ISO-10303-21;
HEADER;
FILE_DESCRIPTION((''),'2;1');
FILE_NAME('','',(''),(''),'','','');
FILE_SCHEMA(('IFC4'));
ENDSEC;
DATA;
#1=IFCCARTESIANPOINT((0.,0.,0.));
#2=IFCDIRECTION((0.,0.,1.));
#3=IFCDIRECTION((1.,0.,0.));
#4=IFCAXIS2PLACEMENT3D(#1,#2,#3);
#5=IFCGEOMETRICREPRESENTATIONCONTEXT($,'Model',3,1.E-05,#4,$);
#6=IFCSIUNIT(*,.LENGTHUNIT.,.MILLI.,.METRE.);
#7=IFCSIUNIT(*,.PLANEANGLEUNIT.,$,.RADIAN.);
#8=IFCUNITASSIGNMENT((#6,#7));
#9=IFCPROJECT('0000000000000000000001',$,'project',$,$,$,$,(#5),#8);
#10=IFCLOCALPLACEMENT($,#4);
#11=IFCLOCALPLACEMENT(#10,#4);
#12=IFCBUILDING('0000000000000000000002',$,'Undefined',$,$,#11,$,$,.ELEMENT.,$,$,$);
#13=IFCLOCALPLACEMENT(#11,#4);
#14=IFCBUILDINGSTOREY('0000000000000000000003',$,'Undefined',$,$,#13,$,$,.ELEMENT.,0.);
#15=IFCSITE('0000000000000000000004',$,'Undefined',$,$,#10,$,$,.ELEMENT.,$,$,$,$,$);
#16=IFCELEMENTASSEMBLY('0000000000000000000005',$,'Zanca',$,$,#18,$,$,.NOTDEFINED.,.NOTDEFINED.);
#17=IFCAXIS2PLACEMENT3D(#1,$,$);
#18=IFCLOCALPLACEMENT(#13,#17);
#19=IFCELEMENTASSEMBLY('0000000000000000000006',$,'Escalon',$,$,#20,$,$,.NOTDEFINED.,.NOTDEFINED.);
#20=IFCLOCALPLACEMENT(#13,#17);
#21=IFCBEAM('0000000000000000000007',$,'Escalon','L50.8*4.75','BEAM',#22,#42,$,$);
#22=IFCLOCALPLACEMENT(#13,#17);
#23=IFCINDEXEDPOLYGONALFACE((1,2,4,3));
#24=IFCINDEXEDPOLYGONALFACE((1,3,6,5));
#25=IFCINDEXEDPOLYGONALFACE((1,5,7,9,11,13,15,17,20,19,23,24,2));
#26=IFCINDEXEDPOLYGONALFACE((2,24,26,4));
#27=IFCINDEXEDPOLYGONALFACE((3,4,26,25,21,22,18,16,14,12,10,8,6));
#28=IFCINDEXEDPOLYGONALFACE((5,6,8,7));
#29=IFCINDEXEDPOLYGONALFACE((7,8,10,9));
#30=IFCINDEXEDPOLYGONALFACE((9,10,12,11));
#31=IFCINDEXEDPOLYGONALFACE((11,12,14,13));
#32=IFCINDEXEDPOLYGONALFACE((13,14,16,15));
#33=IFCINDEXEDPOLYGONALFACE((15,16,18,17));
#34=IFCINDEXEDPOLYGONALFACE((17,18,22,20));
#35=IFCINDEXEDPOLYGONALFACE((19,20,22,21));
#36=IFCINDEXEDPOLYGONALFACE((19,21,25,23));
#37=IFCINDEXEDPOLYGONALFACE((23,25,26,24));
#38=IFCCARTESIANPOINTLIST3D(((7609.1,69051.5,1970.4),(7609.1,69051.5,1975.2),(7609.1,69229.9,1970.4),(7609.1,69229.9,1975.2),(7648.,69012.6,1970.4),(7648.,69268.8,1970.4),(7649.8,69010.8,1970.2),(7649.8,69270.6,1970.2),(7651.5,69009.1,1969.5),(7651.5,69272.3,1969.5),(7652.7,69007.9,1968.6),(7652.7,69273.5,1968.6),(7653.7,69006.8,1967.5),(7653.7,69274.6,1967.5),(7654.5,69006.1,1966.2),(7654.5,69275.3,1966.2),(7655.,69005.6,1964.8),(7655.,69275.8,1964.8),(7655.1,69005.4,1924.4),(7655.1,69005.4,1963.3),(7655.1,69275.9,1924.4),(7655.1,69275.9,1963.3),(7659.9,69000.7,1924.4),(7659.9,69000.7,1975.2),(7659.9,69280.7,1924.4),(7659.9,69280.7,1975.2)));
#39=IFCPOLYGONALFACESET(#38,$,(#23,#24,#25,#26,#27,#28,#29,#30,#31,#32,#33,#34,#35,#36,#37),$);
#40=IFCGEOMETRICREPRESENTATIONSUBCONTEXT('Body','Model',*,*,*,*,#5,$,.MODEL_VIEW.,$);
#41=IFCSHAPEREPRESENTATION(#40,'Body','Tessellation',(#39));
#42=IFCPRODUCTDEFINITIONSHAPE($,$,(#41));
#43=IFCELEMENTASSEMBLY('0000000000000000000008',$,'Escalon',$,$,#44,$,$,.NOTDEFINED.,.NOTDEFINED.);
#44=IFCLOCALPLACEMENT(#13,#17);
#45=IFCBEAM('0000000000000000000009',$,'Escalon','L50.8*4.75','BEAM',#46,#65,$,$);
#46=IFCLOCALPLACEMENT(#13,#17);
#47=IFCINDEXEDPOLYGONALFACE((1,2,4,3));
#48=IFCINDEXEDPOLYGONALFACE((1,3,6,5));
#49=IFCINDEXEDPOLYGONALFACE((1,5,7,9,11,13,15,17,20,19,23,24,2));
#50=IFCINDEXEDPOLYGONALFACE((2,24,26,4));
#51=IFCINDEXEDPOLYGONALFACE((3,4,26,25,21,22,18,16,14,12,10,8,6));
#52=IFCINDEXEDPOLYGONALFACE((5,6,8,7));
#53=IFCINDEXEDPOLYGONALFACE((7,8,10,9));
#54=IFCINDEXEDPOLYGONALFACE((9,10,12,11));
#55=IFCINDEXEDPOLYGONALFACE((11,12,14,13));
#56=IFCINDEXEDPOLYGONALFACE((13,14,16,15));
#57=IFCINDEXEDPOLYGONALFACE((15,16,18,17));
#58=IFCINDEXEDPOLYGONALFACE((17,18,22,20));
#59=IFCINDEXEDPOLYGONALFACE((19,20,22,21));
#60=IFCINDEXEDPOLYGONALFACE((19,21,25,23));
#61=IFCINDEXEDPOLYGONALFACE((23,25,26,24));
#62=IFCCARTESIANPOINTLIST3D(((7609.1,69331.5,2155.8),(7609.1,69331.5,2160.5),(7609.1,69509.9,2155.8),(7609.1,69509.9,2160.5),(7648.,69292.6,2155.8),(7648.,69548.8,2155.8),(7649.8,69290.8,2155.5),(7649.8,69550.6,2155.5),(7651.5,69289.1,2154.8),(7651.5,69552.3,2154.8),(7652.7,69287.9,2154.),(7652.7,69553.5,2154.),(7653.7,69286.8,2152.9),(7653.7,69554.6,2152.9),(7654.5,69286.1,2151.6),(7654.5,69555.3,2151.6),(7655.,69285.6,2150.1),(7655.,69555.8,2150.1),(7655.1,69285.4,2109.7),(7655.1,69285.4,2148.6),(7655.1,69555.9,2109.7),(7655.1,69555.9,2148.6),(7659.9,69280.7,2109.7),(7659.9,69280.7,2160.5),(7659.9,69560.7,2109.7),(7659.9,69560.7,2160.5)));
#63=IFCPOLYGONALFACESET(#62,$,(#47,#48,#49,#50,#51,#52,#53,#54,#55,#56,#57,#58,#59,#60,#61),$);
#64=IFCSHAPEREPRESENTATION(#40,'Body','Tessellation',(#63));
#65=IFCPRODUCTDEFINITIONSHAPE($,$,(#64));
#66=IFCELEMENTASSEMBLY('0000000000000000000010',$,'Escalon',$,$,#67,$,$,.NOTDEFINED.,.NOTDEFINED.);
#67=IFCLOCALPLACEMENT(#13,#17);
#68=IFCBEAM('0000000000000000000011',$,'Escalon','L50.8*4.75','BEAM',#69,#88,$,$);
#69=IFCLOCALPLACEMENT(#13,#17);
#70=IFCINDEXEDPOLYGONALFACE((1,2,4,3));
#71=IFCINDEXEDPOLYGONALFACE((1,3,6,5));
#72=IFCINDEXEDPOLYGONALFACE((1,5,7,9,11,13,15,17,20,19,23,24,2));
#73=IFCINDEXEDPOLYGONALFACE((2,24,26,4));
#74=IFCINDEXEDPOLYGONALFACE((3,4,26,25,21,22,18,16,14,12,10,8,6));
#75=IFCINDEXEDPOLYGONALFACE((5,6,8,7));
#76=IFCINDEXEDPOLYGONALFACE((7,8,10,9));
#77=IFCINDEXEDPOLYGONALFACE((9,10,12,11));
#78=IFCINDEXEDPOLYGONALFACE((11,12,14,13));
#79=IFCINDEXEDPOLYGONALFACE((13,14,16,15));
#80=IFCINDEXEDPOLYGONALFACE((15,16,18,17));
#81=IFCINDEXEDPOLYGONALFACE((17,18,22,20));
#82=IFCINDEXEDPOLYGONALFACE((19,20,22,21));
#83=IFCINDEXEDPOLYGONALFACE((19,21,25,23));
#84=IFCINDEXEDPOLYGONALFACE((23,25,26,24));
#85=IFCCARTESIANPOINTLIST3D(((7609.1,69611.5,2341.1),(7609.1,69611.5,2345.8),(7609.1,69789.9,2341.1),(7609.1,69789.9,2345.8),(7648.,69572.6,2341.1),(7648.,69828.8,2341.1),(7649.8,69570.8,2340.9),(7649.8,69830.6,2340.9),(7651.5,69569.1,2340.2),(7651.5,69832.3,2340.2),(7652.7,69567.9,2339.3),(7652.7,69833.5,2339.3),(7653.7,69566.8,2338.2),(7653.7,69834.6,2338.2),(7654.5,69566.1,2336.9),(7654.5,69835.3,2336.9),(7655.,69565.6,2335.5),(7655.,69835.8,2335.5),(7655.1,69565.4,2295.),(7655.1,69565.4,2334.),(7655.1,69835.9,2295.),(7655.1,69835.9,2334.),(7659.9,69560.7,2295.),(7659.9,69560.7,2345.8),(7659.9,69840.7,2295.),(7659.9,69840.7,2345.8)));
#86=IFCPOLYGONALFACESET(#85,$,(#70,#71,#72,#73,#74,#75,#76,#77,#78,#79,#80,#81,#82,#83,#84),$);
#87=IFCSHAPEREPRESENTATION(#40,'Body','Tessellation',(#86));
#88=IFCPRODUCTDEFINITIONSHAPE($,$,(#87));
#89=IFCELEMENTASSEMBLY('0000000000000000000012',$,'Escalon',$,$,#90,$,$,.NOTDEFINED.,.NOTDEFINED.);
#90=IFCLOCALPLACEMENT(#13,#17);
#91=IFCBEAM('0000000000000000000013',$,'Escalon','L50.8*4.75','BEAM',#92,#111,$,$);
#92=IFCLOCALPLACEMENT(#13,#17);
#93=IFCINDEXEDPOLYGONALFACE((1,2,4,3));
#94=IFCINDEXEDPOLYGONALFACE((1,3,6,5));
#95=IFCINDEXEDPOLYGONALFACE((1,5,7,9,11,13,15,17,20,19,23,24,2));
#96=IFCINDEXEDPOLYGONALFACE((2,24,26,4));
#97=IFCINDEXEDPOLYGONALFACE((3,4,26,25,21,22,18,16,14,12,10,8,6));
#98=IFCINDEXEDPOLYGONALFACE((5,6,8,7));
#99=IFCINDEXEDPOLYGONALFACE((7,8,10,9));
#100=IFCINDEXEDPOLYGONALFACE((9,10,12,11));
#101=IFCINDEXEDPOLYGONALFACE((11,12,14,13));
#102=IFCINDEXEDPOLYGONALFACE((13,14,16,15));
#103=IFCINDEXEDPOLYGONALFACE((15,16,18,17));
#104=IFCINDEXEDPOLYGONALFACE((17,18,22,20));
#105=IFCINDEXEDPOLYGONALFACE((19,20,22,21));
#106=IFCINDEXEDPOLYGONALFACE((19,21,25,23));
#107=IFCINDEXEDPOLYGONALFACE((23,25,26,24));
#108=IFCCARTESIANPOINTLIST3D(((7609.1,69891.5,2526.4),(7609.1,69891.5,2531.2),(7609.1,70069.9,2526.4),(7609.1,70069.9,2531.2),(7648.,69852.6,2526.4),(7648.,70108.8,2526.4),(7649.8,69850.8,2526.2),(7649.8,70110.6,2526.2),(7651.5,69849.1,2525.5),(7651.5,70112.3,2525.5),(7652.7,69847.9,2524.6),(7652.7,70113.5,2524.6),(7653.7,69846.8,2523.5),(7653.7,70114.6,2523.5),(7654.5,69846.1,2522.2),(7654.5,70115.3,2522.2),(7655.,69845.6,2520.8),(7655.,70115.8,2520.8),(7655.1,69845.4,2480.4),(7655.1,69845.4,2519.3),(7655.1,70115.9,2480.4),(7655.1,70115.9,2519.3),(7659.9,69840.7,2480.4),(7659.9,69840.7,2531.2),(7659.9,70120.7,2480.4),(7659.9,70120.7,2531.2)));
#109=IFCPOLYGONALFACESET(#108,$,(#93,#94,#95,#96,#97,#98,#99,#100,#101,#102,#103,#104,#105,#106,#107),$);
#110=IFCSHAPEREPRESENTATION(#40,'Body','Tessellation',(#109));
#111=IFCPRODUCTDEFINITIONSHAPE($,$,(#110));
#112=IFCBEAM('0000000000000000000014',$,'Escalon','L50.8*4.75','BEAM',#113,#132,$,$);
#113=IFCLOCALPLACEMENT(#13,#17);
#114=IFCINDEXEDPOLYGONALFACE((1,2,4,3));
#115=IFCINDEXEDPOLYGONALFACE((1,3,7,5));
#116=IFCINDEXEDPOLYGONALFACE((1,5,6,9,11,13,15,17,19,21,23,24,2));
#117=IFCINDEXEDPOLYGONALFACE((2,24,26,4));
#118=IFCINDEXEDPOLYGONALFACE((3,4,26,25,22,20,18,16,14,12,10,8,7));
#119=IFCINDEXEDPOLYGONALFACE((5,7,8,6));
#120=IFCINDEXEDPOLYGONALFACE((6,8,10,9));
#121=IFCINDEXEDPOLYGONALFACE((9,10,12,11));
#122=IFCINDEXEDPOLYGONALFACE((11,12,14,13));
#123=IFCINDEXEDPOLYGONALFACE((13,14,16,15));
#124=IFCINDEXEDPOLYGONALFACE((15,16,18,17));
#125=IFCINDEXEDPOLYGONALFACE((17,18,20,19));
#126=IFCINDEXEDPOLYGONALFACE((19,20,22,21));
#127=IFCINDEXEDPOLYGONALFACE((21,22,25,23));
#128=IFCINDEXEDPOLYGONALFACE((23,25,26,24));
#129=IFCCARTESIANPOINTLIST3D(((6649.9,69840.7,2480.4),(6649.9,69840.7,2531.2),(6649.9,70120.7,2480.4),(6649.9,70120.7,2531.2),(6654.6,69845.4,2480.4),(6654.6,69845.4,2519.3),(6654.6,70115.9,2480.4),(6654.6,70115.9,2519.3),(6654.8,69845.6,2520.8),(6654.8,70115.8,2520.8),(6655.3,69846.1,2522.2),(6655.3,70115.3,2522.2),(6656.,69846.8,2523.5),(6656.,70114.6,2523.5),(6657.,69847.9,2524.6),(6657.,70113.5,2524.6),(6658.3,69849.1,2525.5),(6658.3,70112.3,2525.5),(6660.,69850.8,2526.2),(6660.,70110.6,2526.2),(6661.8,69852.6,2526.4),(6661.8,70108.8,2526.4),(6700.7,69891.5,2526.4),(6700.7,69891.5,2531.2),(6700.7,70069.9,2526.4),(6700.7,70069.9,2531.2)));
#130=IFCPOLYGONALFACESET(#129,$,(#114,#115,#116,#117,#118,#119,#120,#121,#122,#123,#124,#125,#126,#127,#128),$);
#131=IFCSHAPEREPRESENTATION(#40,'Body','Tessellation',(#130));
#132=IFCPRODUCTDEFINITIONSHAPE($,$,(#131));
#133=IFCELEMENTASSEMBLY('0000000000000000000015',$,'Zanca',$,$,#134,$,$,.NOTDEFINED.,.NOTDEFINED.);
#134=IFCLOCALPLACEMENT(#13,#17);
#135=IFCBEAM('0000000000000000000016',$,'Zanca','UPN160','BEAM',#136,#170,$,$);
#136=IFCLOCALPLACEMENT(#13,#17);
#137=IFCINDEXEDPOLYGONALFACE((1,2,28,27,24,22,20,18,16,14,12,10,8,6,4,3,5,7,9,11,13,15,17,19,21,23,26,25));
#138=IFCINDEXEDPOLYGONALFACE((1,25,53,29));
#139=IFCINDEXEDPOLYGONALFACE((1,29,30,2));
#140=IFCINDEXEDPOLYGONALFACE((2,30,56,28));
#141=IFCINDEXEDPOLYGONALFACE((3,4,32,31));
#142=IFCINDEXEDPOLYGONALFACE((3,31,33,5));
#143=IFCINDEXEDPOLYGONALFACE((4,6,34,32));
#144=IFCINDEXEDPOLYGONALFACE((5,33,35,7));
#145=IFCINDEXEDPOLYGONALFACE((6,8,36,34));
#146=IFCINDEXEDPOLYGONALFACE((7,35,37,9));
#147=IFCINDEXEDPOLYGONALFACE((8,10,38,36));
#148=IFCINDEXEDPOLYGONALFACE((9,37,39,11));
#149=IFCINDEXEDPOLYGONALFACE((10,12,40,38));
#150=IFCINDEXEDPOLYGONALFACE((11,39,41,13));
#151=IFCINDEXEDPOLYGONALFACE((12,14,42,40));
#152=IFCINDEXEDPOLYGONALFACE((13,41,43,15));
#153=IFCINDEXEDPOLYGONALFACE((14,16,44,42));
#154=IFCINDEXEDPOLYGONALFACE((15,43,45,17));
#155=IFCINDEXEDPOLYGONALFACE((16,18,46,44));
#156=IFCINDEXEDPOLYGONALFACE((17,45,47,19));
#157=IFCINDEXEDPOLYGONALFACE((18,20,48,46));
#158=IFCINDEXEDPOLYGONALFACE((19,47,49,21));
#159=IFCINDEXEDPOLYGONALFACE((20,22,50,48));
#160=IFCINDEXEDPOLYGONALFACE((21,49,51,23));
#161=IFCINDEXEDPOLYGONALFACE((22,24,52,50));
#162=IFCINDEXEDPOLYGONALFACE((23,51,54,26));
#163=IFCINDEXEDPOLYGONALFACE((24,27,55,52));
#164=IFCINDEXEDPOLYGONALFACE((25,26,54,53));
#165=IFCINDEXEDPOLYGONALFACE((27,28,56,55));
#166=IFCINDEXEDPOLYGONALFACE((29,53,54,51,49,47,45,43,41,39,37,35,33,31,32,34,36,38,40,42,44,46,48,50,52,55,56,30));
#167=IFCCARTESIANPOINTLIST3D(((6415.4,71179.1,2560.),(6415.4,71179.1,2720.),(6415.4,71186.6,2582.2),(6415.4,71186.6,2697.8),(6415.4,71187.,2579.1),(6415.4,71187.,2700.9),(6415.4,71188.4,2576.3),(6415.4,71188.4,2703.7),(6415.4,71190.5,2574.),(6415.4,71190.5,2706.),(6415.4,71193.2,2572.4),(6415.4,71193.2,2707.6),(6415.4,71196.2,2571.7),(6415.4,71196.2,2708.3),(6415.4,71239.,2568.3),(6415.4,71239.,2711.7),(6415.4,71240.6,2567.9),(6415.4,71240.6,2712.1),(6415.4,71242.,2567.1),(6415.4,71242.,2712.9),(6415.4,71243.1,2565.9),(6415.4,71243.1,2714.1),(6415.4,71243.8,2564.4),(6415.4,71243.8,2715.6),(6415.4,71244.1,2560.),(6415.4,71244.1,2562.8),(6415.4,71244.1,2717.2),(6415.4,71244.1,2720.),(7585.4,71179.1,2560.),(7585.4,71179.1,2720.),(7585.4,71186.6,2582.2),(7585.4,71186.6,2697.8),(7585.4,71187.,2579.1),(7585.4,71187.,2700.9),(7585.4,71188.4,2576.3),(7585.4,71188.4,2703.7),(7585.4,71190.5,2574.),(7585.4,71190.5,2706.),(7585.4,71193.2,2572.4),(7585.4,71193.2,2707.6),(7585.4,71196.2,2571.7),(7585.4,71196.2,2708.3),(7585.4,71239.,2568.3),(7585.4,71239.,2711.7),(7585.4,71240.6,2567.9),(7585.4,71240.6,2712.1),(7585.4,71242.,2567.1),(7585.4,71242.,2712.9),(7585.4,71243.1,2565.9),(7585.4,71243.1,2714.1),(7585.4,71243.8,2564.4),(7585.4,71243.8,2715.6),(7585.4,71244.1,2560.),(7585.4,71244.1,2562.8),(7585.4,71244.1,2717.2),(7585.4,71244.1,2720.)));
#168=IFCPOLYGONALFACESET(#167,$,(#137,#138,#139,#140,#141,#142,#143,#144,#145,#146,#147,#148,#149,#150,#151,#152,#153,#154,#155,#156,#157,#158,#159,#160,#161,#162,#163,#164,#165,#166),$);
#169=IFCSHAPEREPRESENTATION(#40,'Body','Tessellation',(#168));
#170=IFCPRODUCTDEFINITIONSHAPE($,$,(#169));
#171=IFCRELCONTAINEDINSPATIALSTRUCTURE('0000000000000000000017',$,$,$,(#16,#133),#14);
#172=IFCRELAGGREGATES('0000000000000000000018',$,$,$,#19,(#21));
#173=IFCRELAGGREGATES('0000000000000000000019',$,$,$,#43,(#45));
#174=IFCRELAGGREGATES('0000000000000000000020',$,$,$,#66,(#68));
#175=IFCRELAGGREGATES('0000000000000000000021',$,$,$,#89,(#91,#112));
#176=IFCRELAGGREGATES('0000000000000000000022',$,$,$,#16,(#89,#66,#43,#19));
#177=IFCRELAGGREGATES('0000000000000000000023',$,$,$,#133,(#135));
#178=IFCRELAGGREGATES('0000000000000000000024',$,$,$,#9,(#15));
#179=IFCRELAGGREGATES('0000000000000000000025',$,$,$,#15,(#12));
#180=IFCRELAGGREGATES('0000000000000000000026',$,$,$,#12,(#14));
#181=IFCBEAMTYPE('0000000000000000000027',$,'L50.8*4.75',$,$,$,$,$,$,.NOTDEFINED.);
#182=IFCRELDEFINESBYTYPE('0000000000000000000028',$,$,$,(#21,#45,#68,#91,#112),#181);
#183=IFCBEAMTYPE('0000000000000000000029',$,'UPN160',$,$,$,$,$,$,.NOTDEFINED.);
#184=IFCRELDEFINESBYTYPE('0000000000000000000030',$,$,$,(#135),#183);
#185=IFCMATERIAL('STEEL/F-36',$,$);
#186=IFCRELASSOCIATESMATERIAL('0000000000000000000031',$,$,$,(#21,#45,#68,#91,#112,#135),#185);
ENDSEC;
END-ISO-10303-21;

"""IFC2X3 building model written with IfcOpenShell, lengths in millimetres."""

from ifc_helpers import new_model, si_unit, frame, origin_with_axes, origin_2d_with_axis, place, context, subcontext, project, spatial, l_section, u_section, extrude, clip, halfspace, material, type_object, element, aggregate, save


model = new_model("IFC2X3")

# Units and contexts
model_context = context("Model", 3, precision=1e-05, world=origin_with_axes())
body_context = subcontext(model_context, "Body", "Model", "MODEL_VIEW")
ifc_project = project(units=[si_unit("LENGTHUNIT", "METRE", prefix="MILLI"), si_unit("PLANEANGLEUNIT", "RADIAN")], contexts=[model_context])

# Site, building, storey
site_placement = place(None, origin_with_axes())
site = spatial("IfcSite", under=ifc_project, at=site_placement, Name="Undefined", CompositionType="ELEMENT")
building_placement = place(site_placement, origin_with_axes())
building = spatial("IfcBuilding", under=site, at=building_placement, Name="Undefined", CompositionType="ELEMENT")
storey_placement = place(building_placement, origin_with_axes())
storey = spatial("IfcBuildingStorey", under=building, at=storey_placement, Name="Undefined", CompositionType="ELEMENT", Elevation=0.0)

# Element assemblies, beams
assembly_1_placement = place(storey_placement, origin_with_axes())
assembly_1 = element("IfcElementAssembly", 1, at=assembly_1_placement, inside=storey, Name="Zanca", AssemblyPlace="NOTDEFINED", PredefinedType="NOTDEFINED")
ifc_material_1 = material(Name="STEEL/F-36")
beam_type_1 = type_object("IfcBeamType", Name="L50.8*4.75", PredefinedType="NOTDEFINED")
assembly_2_placement = place(assembly_1_placement, origin_with_axes())
assembly_2 = element("IfcElementAssembly", 2, at=assembly_2_placement, Name="Escalon", AssemblyPlace="NOTDEFINED", PredefinedType="NOTDEFINED")
beam_1_placement = place(assembly_2_placement, frame((7634.5, 69000.7, 1949.8), z_axis=(0.0, 0.0, -1.0), x_axis=(0.0, 1.0, 0.0)))
beam_1 = element("IfcBeam", 3, at=beam_1_placement, type_object=beam_type_1, material=ifc_material_1, Name="Escalon", Description="L50.8*4.75", ObjectType="BEAM", context=body_context, shape_type="Clipping", body=[
    clip(clip(extrude(l_section(Depth=50.8, Width=50.8, Thickness=4.8, FilletRadius=7.1, at=origin_2d_with_axis()), frame((305.9, 0.0, 0.0), z_axis=(-1.0, 0.0, 0.0), x_axis=(0.0, -1.0, 0.0)), (0.0, 0.0, 1.0), 331.8), halfspace(frame((229.2, -25.4, 0.0), z_axis=(-0.707107, 0.707107, 0.0), x_axis=(0.0, 0.0, -1.0)), True)), halfspace(frame((50.8, -25.4, 0.0), z_axis=(-0.707107, -0.707107, 0.0), x_axis=(0.0, 0.0, -1.0)), False)),
])
aggregate(assembly_2, [beam_1])
assembly_3_placement = place(assembly_1_placement, origin_with_axes())
assembly_3 = element("IfcElementAssembly", 4, at=assembly_3_placement, Name="Escalon", AssemblyPlace="NOTDEFINED", PredefinedType="NOTDEFINED")
beam_2_placement = place(assembly_3_placement, frame((7634.5, 69280.7, 2135.1), z_axis=(0.0, 0.0, -1.0), x_axis=(0.0, 1.0, 0.0)))
beam_2 = element("IfcBeam", 5, at=beam_2_placement, type_object=beam_type_1, material=ifc_material_1, Name="Escalon", Description="L50.8*4.75", ObjectType="BEAM", context=body_context, shape_type="Clipping", body=[
    clip(clip(extrude(l_section(Depth=50.8, Width=50.8, Thickness=4.8, FilletRadius=7.1, at=origin_2d_with_axis()), frame((305.9, 0.0, 0.0), z_axis=(-1.0, 0.0, 0.0), x_axis=(0.0, -1.0, 0.0)), (0.0, 0.0, 1.0), 331.8), halfspace(frame((229.2, -25.4, 0.0), z_axis=(-0.707107, 0.707107, 0.0), x_axis=(0.0, 0.0, -1.0)), True)), halfspace(frame((50.8, -25.4, 0.0), z_axis=(-0.707107, -0.707107, 0.0), x_axis=(0.0, 0.0, -1.0)), False)),
])
aggregate(assembly_3, [beam_2])
assembly_4_placement = place(assembly_1_placement, origin_with_axes())
assembly_4 = element("IfcElementAssembly", 6, at=assembly_4_placement, Name="Escalon", AssemblyPlace="NOTDEFINED", PredefinedType="NOTDEFINED")
beam_3_placement = place(assembly_4_placement, frame((7634.5, 69560.7, 2320.4), z_axis=(0.0, 0.0, -1.0), x_axis=(0.0, 1.0, 0.0)))
beam_3 = element("IfcBeam", 7, at=beam_3_placement, type_object=beam_type_1, material=ifc_material_1, Name="Escalon", Description="L50.8*4.75", ObjectType="BEAM", context=body_context, shape_type="Clipping", body=[
    clip(clip(extrude(l_section(Depth=50.8, Width=50.8, Thickness=4.8, FilletRadius=7.1, at=origin_2d_with_axis()), frame((305.9, 0.0, 0.0), z_axis=(-1.0, 0.0, 0.0), x_axis=(0.0, -1.0, 0.0)), (0.0, 0.0, 1.0), 331.8), halfspace(frame((229.2, -25.4, 0.0), z_axis=(-0.707107, 0.707107, 0.0), x_axis=(0.0, 0.0, -1.0)), True)), halfspace(frame((50.8, -25.4, 0.0), z_axis=(-0.707107, -0.707107, 0.0), x_axis=(0.0, 0.0, -1.0)), False)),
])
aggregate(assembly_4, [beam_3])
assembly_5_placement = place(assembly_1_placement, origin_with_axes())
assembly_5 = element("IfcElementAssembly", 8, at=assembly_5_placement, Name="Escalon", AssemblyPlace="NOTDEFINED", PredefinedType="NOTDEFINED")
beam_4_placement = place(assembly_5_placement, frame((7634.5, 69840.7, 2505.8), z_axis=(0.0, 0.0, -1.0), x_axis=(0.0, 1.0, 0.0)))
beam_4 = element("IfcBeam", 9, at=beam_4_placement, type_object=beam_type_1, material=ifc_material_1, Name="Escalon", Description="L50.8*4.75", ObjectType="BEAM", context=body_context, shape_type="Clipping", body=[
    clip(clip(extrude(l_section(Depth=50.8, Width=50.8, Thickness=4.8, FilletRadius=7.1, at=origin_2d_with_axis()), frame((305.9, 0.0, 0.0), z_axis=(-1.0, 0.0, 0.0), x_axis=(0.0, -1.0, 0.0)), (0.0, 0.0, 1.0), 331.8), halfspace(frame((229.2, -25.4, 0.0), z_axis=(-0.707107, 0.707107, 0.0), x_axis=(0.0, 0.0, -1.0)), True)), halfspace(frame((50.8, -25.4, 0.0), z_axis=(-0.707107, -0.707107, 0.0), x_axis=(0.0, 0.0, -1.0)), False)),
])
beam_5_placement = place(assembly_5_placement, frame((6675.3, 70120.7, 2505.8), z_axis=(0.0, 0.0, -1.0), x_axis=(0.0, -1.0, 0.0)))
beam_5 = element("IfcBeam", 10, at=beam_5_placement, type_object=beam_type_1, material=ifc_material_1, Name="Escalon", Description="L50.8*4.75", ObjectType="BEAM", context=body_context, shape_type="Clipping", body=[
    clip(clip(extrude(l_section(Depth=50.8, Width=50.8, Thickness=4.8, FilletRadius=7.1, at=origin_2d_with_axis()), frame((305.9, 0.0, 0.0), z_axis=(-1.0, 0.0, 0.0), x_axis=(0.0, -1.0, 0.0)), (0.0, 0.0, 1.0), 331.8), halfspace(frame((229.2, -25.4, 0.0), z_axis=(-0.707107, 0.707107, 0.0), x_axis=(0.0, 0.0, -1.0)), True)), halfspace(frame((50.8, -25.4, 0.0), z_axis=(-0.707107, -0.707107, 0.0), x_axis=(0.0, 0.0, -1.0)), False)),
])
aggregate(assembly_5, [beam_4, beam_5])

# Element assembly, beam
assembly_6_placement = place(storey_placement, origin_with_axes())
assembly_6 = element("IfcElementAssembly", 11, at=assembly_6_placement, inside=storey, Name="Zanca", AssemblyPlace="NOTDEFINED", PredefinedType="NOTDEFINED")
beam_type_2 = type_object("IfcBeamType", Name="UPN160", PredefinedType="NOTDEFINED")
beam_6_placement = place(assembly_6_placement, frame((7585.4, 71211.6, 2640.0), z_axis=(0.0, 0.0, 1.0), x_axis=(-1.0, 0.0, 0.0)))
beam_6 = element("IfcBeam", 12, at=beam_6_placement, type_object=beam_type_2, material=ifc_material_1, Name="Zanca", Description="UPN160", ObjectType="BEAM", context=body_context, shape_type="SweptSolid", body=[
    extrude(u_section(Depth=160.0, FlangeWidth=65.0, WebThickness=7.5, FlangeThickness=10.5, FilletRadius=10.5, EdgeRadius=5.5, FlangeSlope=0.07983, at=origin_2d_with_axis()), frame((1170.0, 0.0, 0.0), z_axis=(-1.0, 0.0, 0.0), x_axis=(0.0, -1.0, 0.0)), (0.0, 0.0, 1.0), 1170.0),
])

aggregate(assembly_1, [assembly_5, assembly_4, assembly_3, assembly_2])

aggregate(assembly_6, [beam_6])

save(model, "model.ifc")
